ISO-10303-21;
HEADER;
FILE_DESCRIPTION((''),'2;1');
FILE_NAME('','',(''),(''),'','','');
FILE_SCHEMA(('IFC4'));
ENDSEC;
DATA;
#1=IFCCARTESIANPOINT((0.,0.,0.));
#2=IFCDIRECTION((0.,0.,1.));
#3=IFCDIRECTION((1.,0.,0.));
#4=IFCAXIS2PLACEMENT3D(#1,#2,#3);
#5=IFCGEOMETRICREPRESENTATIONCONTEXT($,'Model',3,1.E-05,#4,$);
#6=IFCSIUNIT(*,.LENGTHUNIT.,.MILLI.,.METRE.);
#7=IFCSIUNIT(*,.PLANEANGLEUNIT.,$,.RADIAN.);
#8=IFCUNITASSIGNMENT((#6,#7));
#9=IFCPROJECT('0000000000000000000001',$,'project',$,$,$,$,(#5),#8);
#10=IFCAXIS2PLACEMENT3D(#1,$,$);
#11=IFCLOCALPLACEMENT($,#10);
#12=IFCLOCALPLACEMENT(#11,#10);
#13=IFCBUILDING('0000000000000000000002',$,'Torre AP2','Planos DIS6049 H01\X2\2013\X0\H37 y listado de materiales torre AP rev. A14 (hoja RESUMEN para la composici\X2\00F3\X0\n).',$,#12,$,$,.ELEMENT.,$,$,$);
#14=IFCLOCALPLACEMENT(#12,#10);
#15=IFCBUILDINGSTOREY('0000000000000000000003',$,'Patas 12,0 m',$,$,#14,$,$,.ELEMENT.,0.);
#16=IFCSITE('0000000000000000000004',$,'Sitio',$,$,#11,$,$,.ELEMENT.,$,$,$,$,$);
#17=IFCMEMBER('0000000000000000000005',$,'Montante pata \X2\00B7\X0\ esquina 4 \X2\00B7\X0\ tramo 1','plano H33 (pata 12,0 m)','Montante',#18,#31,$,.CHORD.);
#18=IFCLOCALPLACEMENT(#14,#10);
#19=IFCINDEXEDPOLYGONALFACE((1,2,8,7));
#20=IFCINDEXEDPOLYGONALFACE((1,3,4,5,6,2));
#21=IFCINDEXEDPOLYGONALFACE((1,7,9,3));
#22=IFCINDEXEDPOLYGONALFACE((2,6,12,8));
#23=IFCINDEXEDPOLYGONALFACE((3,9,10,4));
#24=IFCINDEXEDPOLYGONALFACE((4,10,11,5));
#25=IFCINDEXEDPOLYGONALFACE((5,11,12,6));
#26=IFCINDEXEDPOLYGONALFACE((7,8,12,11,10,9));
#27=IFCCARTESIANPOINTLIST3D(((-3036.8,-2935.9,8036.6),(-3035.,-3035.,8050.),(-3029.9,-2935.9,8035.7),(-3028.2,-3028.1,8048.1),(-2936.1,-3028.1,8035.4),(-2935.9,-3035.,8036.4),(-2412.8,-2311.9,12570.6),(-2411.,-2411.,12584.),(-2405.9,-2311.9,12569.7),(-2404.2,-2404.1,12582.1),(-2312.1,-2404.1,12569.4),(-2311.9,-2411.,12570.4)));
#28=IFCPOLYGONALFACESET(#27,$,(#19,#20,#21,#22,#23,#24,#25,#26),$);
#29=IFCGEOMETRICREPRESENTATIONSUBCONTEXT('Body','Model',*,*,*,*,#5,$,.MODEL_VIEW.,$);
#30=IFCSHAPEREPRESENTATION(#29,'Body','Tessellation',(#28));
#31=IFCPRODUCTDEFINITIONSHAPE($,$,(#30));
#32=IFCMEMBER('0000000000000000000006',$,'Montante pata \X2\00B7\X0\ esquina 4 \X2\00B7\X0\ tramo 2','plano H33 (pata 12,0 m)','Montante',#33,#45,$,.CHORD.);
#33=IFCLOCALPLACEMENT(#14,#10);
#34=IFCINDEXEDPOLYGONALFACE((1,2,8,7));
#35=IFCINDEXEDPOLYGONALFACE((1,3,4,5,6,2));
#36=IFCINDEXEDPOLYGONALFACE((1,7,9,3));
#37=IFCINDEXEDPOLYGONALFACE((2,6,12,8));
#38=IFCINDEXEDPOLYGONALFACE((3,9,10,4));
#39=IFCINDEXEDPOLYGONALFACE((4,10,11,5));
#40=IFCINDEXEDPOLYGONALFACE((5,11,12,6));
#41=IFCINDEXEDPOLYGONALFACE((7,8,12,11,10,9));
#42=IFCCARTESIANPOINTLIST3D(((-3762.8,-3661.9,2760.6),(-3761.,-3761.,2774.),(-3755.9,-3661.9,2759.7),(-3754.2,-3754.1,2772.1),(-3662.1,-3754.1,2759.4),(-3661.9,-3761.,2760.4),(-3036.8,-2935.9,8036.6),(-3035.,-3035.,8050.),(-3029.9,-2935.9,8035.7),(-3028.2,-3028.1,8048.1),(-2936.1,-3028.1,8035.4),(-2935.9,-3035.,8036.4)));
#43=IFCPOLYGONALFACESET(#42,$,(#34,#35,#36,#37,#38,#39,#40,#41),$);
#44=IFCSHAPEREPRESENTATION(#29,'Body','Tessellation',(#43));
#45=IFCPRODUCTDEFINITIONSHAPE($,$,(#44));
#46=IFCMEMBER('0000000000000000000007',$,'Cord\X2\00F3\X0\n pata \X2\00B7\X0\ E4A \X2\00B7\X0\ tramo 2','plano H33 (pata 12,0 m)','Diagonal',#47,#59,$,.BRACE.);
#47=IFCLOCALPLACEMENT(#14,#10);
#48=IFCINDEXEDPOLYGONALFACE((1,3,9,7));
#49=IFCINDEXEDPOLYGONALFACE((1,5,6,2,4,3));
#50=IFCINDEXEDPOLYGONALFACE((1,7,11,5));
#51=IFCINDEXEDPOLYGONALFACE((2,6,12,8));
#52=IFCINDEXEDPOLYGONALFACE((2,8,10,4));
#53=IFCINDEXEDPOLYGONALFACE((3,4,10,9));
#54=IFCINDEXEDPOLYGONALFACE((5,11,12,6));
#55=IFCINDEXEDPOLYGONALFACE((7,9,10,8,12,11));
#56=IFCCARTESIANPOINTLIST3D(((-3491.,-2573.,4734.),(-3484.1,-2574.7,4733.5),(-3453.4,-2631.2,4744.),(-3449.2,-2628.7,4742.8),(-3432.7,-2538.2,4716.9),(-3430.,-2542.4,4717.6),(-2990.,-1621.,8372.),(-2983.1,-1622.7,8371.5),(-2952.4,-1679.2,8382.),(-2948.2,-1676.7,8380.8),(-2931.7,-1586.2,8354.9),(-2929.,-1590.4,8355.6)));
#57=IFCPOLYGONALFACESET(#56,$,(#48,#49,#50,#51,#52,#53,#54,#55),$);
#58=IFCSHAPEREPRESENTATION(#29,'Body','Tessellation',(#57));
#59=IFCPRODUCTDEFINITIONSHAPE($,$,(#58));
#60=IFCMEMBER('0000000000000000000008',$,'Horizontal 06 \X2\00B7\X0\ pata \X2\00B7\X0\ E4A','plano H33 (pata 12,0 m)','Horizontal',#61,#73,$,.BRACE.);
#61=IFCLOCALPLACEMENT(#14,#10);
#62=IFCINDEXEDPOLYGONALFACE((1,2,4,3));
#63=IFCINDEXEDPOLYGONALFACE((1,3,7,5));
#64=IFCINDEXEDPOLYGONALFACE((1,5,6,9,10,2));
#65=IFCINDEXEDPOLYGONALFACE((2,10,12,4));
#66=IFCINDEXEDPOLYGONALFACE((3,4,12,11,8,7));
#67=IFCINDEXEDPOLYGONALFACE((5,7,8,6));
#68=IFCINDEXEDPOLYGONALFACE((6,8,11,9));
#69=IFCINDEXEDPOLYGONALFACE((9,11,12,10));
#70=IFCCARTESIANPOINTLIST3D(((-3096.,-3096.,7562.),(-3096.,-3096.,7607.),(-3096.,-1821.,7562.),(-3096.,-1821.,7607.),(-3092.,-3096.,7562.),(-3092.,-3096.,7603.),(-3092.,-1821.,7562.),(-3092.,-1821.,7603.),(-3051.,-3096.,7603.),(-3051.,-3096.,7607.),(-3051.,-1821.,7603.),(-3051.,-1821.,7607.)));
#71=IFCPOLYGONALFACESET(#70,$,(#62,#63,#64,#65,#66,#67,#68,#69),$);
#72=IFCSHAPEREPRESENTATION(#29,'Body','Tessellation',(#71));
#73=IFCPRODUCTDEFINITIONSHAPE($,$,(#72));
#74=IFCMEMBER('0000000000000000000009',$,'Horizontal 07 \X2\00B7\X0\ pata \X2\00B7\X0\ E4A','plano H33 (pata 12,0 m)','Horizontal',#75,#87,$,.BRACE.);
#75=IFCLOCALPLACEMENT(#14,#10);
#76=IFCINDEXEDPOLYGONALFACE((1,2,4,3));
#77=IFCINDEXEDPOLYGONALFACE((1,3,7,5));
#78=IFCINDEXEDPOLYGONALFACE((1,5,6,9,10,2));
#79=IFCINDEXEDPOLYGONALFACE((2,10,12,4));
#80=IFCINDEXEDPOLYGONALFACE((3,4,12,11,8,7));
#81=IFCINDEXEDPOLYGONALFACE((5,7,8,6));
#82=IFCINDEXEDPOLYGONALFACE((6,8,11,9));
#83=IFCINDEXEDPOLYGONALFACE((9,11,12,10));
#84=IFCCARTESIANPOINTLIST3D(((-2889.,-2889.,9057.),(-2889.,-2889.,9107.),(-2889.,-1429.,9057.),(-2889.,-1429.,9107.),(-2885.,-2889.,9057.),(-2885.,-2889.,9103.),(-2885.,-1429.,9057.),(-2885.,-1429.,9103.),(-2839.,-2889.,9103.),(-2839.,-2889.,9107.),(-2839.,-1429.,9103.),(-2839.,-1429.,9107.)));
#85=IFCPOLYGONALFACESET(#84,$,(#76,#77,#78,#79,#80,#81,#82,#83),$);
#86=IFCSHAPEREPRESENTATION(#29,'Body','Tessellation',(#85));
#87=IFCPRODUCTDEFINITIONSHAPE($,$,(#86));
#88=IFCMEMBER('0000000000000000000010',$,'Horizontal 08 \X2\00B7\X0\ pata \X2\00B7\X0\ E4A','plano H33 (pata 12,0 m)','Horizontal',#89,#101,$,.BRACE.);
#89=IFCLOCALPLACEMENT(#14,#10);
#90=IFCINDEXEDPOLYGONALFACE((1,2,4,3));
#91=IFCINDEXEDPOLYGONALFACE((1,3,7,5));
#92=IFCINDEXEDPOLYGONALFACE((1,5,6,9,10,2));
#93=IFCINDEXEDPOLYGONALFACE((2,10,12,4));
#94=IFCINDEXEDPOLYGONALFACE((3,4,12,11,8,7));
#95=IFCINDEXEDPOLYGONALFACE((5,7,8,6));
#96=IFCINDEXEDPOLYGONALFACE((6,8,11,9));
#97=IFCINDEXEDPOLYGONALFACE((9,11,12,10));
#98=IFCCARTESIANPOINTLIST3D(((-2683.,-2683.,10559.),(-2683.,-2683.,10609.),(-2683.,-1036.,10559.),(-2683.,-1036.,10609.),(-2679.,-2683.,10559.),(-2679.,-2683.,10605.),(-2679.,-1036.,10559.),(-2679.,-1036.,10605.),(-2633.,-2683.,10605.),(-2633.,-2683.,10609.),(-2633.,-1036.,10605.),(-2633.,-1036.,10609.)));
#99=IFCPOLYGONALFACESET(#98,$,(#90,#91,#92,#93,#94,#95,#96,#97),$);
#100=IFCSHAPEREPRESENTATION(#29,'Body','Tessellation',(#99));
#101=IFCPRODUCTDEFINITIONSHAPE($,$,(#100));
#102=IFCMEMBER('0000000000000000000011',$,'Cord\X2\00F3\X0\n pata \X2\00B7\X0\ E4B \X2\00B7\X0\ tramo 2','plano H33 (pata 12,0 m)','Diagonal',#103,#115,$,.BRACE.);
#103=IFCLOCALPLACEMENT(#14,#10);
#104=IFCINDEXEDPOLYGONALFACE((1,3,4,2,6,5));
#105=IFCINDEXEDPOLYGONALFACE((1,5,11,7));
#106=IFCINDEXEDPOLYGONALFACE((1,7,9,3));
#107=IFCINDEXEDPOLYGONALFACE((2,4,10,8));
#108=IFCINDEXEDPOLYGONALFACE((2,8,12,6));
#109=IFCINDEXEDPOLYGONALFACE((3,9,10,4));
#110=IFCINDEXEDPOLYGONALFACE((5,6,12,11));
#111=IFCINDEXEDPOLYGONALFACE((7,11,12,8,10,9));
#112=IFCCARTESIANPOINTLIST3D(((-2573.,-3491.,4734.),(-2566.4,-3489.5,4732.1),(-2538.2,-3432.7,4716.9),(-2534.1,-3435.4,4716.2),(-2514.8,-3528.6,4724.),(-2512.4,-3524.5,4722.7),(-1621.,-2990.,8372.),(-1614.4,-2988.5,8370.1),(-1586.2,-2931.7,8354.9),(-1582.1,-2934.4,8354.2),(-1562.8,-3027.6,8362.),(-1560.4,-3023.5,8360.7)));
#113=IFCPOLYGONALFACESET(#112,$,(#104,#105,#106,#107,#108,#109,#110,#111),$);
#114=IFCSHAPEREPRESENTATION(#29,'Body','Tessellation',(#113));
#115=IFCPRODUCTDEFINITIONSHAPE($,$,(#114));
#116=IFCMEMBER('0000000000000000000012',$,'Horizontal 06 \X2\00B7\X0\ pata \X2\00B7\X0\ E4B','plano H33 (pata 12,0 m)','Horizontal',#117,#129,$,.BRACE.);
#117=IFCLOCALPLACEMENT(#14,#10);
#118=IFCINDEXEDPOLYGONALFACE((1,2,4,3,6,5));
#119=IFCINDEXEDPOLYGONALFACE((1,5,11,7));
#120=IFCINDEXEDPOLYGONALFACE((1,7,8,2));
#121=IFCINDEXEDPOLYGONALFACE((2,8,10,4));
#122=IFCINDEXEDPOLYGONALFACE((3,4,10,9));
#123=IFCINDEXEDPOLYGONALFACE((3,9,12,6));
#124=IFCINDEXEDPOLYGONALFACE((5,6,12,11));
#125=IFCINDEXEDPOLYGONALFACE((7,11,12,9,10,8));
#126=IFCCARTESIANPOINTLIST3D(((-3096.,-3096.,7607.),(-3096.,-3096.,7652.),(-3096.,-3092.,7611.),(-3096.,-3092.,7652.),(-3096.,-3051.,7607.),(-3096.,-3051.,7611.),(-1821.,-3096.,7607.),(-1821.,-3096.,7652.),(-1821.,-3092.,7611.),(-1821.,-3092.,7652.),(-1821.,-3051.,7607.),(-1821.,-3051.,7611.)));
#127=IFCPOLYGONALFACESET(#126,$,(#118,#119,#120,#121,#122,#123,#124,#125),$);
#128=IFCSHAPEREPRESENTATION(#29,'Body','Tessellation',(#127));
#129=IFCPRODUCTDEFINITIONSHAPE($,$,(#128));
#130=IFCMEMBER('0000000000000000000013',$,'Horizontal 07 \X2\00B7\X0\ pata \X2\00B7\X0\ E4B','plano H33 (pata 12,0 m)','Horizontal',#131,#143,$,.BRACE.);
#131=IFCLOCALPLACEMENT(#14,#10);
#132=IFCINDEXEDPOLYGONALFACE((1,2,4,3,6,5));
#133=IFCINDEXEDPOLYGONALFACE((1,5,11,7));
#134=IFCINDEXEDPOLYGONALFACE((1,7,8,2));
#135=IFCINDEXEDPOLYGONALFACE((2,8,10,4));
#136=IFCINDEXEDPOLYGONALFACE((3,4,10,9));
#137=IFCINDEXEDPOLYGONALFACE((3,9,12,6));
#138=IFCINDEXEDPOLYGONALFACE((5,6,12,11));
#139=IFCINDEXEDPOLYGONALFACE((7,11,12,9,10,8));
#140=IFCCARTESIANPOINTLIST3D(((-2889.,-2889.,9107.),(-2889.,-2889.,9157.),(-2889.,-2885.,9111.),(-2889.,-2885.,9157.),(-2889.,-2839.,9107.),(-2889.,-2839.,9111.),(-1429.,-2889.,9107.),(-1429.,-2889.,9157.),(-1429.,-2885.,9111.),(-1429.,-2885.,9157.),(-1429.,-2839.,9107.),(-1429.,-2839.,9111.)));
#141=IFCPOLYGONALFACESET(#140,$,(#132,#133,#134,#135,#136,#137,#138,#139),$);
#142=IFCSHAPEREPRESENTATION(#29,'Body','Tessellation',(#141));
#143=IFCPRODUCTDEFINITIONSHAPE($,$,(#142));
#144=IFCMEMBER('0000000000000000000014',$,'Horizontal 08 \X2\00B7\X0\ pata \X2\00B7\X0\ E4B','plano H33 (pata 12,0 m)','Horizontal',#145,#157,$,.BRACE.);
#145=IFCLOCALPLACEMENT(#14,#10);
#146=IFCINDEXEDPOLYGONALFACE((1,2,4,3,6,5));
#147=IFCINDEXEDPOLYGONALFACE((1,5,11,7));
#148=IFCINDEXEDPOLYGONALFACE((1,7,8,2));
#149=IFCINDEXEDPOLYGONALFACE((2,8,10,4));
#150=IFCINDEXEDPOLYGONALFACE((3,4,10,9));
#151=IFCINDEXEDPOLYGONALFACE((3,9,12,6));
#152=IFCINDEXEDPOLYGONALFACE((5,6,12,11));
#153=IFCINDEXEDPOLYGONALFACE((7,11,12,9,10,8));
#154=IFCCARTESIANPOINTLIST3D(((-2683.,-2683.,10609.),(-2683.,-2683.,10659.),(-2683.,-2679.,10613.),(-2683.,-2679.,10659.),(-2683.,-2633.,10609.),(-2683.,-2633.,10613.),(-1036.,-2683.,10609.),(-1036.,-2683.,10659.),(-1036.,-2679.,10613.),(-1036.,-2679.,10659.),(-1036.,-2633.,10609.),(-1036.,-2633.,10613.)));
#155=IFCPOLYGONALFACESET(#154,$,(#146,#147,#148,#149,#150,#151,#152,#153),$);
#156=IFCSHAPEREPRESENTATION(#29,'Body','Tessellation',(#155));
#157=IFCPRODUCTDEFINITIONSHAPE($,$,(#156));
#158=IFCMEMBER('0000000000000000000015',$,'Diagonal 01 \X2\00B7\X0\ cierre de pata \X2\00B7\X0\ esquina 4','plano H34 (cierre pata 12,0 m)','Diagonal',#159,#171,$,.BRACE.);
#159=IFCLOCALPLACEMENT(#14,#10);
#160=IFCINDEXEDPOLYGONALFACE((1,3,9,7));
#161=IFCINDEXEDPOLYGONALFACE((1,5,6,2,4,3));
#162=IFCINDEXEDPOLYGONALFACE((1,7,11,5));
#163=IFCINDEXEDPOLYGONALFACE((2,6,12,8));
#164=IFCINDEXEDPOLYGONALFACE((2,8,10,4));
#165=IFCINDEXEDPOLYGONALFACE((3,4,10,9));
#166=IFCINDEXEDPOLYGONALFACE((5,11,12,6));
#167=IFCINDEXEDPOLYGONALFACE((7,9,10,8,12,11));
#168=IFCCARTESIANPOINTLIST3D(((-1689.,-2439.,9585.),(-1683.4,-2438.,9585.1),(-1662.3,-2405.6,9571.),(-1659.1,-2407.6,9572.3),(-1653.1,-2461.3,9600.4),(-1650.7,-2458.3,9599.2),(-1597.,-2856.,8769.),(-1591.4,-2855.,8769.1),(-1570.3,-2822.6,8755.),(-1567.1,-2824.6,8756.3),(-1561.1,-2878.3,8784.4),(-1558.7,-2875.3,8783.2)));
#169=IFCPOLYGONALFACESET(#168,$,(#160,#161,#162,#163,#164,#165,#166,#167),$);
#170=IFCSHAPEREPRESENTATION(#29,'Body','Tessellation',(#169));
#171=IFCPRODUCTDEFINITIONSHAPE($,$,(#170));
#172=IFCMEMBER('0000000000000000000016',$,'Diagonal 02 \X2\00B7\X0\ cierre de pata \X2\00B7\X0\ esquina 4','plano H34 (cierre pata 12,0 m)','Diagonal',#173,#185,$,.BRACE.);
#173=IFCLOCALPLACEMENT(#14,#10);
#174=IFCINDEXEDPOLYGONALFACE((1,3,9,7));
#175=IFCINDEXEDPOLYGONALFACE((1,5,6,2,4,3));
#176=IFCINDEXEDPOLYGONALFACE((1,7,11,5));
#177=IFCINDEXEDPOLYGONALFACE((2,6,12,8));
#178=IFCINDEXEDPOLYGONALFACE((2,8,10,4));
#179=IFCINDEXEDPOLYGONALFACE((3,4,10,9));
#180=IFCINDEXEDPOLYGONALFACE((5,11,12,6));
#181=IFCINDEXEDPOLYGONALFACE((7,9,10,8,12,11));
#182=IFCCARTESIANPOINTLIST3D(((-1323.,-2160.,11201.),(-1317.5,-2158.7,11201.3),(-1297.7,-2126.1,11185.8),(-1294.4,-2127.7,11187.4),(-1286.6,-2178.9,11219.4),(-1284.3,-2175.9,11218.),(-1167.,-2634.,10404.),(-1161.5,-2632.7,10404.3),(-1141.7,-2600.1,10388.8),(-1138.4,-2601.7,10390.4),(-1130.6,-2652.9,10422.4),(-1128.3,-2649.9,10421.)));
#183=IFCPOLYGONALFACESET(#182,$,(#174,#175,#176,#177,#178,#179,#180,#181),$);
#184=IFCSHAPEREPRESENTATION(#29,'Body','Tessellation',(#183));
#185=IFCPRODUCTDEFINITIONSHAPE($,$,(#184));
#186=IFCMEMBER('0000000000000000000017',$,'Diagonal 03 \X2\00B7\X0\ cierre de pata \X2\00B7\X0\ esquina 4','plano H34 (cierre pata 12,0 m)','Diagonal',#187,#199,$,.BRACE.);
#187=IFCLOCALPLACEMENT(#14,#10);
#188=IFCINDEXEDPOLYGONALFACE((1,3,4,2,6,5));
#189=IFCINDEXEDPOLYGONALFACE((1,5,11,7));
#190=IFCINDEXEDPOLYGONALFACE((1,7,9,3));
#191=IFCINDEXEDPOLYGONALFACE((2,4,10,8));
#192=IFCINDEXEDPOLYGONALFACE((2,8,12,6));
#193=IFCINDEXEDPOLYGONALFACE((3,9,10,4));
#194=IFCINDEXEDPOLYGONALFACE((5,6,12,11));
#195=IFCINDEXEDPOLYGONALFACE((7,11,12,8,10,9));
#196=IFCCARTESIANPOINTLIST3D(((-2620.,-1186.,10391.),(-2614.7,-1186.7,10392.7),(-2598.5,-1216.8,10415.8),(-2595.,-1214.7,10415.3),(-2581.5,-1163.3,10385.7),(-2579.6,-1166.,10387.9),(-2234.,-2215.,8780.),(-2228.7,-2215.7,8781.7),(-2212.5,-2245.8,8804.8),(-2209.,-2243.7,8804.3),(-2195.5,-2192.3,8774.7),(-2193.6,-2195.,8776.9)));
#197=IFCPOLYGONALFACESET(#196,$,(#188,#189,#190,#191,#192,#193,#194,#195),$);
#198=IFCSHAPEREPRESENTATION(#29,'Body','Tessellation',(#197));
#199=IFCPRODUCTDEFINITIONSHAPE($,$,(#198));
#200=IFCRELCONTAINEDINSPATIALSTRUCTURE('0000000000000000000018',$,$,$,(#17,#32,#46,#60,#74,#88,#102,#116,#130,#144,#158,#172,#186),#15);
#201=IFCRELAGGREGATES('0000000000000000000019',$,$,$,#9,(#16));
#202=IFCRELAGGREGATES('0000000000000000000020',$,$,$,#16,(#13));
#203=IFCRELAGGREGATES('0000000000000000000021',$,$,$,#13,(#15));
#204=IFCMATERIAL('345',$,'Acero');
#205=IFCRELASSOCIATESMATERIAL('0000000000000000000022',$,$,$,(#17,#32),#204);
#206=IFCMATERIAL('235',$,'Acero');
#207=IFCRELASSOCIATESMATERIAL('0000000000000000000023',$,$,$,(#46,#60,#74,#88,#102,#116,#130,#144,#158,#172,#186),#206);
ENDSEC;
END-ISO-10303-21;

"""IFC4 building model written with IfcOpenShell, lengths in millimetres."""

from ifc_helpers import new_model, si_unit, frame, frame_2d, origin, origin_with_axes, place, context, subcontext, project, spatial, l_section, extrude, material, element, save


model = new_model("IFC4")

# Units and contexts
model_context = context("Model", 3, precision=1e-05, world=origin_with_axes())
body_context = subcontext(model_context, "Body", "Model", "MODEL_VIEW")
ifc_project = project(units=[si_unit("LENGTHUNIT", "METRE", prefix="MILLI"), si_unit("PLANEANGLEUNIT", "RADIAN")], contexts=[model_context])

# Site, building, storey
site_placement = place(None, origin())
site = spatial("IfcSite", under=ifc_project, at=site_placement, Name="Sitio", CompositionType="ELEMENT")
building_placement = place(site_placement, origin())
building = spatial("IfcBuilding", under=site, at=building_placement, Name="Torre AP2", Description="Planos DIS6049 H01–H37 y listado de materiales torre AP rev. A14 (hoja RESUMEN para la composición).", CompositionType="ELEMENT")
storey_placement = place(building_placement, origin())
storey = spatial("IfcBuildingStorey", under=building, at=storey_placement, Name="Patas 12,0 m", CompositionType="ELEMENT", Elevation=0.0)

# Members
ifc_material_1 = material(Name="345", Category="Acero")
member_1_placement = place(storey_placement, frame((-2411.0, -2411.0, 12584.0), z_axis=(-0.135092, -0.135092, -0.981581), x_axis=(-0.018419, 0.990833, -0.13383)))
element("IfcMember", 1, at=member_1_placement, inside=storey, material=ifc_material_1, Name="Montante pata · esquina 4 · tramo 1", Description="plano H33 (pata 12,0 m)", ObjectType="Montante", PredefinedType="CHORD", context=body_context, shape_type="SweptSolid", body=[
    extrude(l_section(Depth=100.0, Width=100.0, Thickness=7.0, at=frame_2d((50.0, 50.0))), None, (0.0, 0.0, 1.0), 4619.1),
])
member_2_placement = place(storey_placement, frame((-3035.0, -3035.0, 8050.0), z_axis=(-0.13507, -0.13507, -0.981586), x_axis=(-0.018413, 0.990836, -0.13381)))
element("IfcMember", 2, at=member_2_placement, inside=storey, material=ifc_material_1, Name="Montante pata · esquina 4 · tramo 2", Description="plano H33 (pata 12,0 m)", ObjectType="Montante", PredefinedType="CHORD", context=body_context, shape_type="SweptSolid", body=[
    extrude(l_section(Depth=100.0, Width=100.0, Thickness=7.0, at=frame_2d((50.0, 50.0))), None, (0.0, 0.0, 1.0), 5375.0),
])
ifc_material_2 = material(Name="235", Category="Acero")
member_3_placement = place(storey_placement, frame((-2990.0, -1621.0, 8372.0), z_axis=(-0.13206, -0.250941, -0.958952), x_axis=(0.832746, 0.49667, -0.24465)))
element("IfcMember", 3, at=member_3_placement, inside=storey, material=ifc_material_2, Name="Cordón pata · E4A · tramo 2", Description="plano H33 (pata 12,0 m)", ObjectType="Diagonal", PredefinedType="BRACE", context=body_context, shape_type="SweptSolid", body=[
    extrude(l_section(Depth=70.0, Width=70.0, Thickness=5.0, at=frame_2d((35.0, 35.0))), None, (0.0, 0.0, 1.0), 3793.7),
])
member_4_placement = place(storey_placement, frame((-3096.0, -3096.0, 7607.0), z_axis=(0.0, 1.0, 0.0), x_axis=(1.0, 0.0, 0.0)))
element("IfcMember", 4, at=member_4_placement, inside=storey, material=ifc_material_2, Name="Horizontal 06 · pata · E4A", Description="plano H33 (pata 12,0 m)", ObjectType="Horizontal", PredefinedType="BRACE", context=body_context, shape_type="SweptSolid", body=[
    extrude(l_section(Depth=45.0, Width=45.0, Thickness=4.0, at=frame_2d((22.5, 22.5))), None, (0.0, 0.0, 1.0), 1275.0),
])
member_5_placement = place(storey_placement, frame((-2889.0, -2889.0, 9107.0), z_axis=(0.0, 1.0, 0.0), x_axis=(1.0, 0.0, 0.0)))
element("IfcMember", 5, at=member_5_placement, inside=storey, material=ifc_material_2, Name="Horizontal 07 · pata · E4A", Description="plano H33 (pata 12,0 m)", ObjectType="Horizontal", PredefinedType="BRACE", context=body_context, shape_type="SweptSolid", body=[
    extrude(l_section(Depth=50.0, Width=50.0, Thickness=4.0, at=frame_2d((25.0, 25.0))), None, (0.0, 0.0, 1.0), 1460.0),
])
member_6_placement = place(storey_placement, frame((-2683.0, -2683.0, 10609.0), z_axis=(0.0, 1.0, 0.0), x_axis=(1.0, 0.0, 0.0)))
element("IfcMember", 6, at=member_6_placement, inside=storey, material=ifc_material_2, Name="Horizontal 08 · pata · E4A", Description="plano H33 (pata 12,0 m)", ObjectType="Horizontal", PredefinedType="BRACE", context=body_context, shape_type="SweptSolid", body=[
    extrude(l_section(Depth=50.0, Width=50.0, Thickness=4.0, at=frame_2d((25.0, 25.0))), None, (0.0, 0.0, 1.0), 1647.0),
])
member_7_placement = place(storey_placement, frame((-1621.0, -2990.0, 8372.0), z_axis=(-0.250941, -0.13206, -0.958952), x_axis=(0.49667, 0.832746, -0.24465)))
element("IfcMember", 7, at=member_7_placement, inside=storey, material=ifc_material_2, Name="Cordón pata · E4B · tramo 2", Description="plano H33 (pata 12,0 m)", ObjectType="Diagonal", PredefinedType="BRACE", context=body_context, shape_type="SweptSolid", body=[
    extrude(l_section(Depth=70.0, Width=70.0, Thickness=5.0, at=frame_2d((35.0, 35.0))), None, (0.0, 0.0, 1.0), 3793.7),
])
member_8_placement = place(storey_placement, frame((-3096.0, -3096.0, 7607.0), z_axis=(1.0, 0.0, 0.0), x_axis=(0.0, 1.0, 0.0)))
element("IfcMember", 8, at=member_8_placement, inside=storey, material=ifc_material_2, Name="Horizontal 06 · pata · E4B", Description="plano H33 (pata 12,0 m)", ObjectType="Horizontal", PredefinedType="BRACE", context=body_context, shape_type="SweptSolid", body=[
    extrude(l_section(Depth=45.0, Width=45.0, Thickness=4.0, at=frame_2d((22.5, 22.5))), None, (0.0, 0.0, 1.0), 1275.0),
])
member_9_placement = place(storey_placement, frame((-2889.0, -2889.0, 9107.0), z_axis=(1.0, 0.0, 0.0), x_axis=(0.0, 1.0, 0.0)))
element("IfcMember", 9, at=member_9_placement, inside=storey, material=ifc_material_2, Name="Horizontal 07 · pata · E4B", Description="plano H33 (pata 12,0 m)", ObjectType="Horizontal", PredefinedType="BRACE", context=body_context, shape_type="SweptSolid", body=[
    extrude(l_section(Depth=50.0, Width=50.0, Thickness=4.0, at=frame_2d((25.0, 25.0))), None, (0.0, 0.0, 1.0), 1460.0),
])
member_10_placement = place(storey_placement, frame((-2683.0, -2683.0, 10609.0), z_axis=(1.0, 0.0, 0.0), x_axis=(0.0, 1.0, 0.0)))
element("IfcMember", 10, at=member_10_placement, inside=storey, material=ifc_material_2, Name="Horizontal 08 · pata · E4B", Description="plano H33 (pata 12,0 m)", ObjectType="Horizontal", PredefinedType="BRACE", context=body_context, shape_type="SweptSolid", body=[
    extrude(l_section(Depth=50.0, Width=50.0, Thickness=4.0, at=frame_2d((25.0, 25.0))), None, (0.0, 0.0, 1.0), 1647.0),
])
member_11_placement = place(storey_placement, frame((-1689.0, -2439.0, 9585.0), z_axis=(0.099893, -0.452777, -0.88601), x_axis=(0.594179, 0.741403, -0.311888)))
element("IfcMember", 11, at=member_11_placement, inside=storey, material=ifc_material_2, Name="Diagonal 01 · cierre de pata · esquina 4", Description="plano H34 (cierre pata 12,0 m)", ObjectType="Diagonal", PredefinedType="BRACE", context=body_context, shape_type="SweptSolid", body=[
    extrude(l_section(Depth=45.0, Width=45.0, Thickness=4.0, at=frame_2d((22.5, 22.5))), None, (0.0, 0.0, 1.0), 921.0),
])
member_12_placement = place(storey_placement, frame((-1323.0, -2160.0, 11201.0), z_axis=(0.165899, -0.504078, -0.847575), x_axis=(0.56258, 0.754279, -0.338477)))
element("IfcMember", 12, at=member_12_placement, inside=storey, material=ifc_material_2, Name="Diagonal 02 · cierre de pata · esquina 4", Description="plano H34 (cierre pata 12,0 m)", ObjectType="Diagonal", PredefinedType="BRACE", context=body_context, shape_type="SweptSolid", body=[
    extrude(l_section(Depth=45.0, Width=45.0, Thickness=4.0, at=frame_2d((22.5, 22.5))), None, (0.0, 0.0, 1.0), 940.3),
])
member_13_placement = place(storey_placement, frame((-2620.0, -1186.0, 10391.0), z_axis=(0.197932, -0.527647, -0.826082), x_axis=(0.855328, 0.504616, -0.117376)))
element("IfcMember", 13, at=member_13_placement, inside=storey, material=ifc_material_2, Name="Diagonal 03 · cierre de pata · esquina 4", Description="plano H34 (cierre pata 12,0 m)", ObjectType="Diagonal", PredefinedType="BRACE", context=body_context, shape_type="SweptSolid", body=[
    extrude(l_section(Depth=45.0, Width=45.0, Thickness=4.0, at=frame_2d((22.5, 22.5))), None, (0.0, 0.0, 1.0), 1950.2),
])

save(model, "model.ifc")
